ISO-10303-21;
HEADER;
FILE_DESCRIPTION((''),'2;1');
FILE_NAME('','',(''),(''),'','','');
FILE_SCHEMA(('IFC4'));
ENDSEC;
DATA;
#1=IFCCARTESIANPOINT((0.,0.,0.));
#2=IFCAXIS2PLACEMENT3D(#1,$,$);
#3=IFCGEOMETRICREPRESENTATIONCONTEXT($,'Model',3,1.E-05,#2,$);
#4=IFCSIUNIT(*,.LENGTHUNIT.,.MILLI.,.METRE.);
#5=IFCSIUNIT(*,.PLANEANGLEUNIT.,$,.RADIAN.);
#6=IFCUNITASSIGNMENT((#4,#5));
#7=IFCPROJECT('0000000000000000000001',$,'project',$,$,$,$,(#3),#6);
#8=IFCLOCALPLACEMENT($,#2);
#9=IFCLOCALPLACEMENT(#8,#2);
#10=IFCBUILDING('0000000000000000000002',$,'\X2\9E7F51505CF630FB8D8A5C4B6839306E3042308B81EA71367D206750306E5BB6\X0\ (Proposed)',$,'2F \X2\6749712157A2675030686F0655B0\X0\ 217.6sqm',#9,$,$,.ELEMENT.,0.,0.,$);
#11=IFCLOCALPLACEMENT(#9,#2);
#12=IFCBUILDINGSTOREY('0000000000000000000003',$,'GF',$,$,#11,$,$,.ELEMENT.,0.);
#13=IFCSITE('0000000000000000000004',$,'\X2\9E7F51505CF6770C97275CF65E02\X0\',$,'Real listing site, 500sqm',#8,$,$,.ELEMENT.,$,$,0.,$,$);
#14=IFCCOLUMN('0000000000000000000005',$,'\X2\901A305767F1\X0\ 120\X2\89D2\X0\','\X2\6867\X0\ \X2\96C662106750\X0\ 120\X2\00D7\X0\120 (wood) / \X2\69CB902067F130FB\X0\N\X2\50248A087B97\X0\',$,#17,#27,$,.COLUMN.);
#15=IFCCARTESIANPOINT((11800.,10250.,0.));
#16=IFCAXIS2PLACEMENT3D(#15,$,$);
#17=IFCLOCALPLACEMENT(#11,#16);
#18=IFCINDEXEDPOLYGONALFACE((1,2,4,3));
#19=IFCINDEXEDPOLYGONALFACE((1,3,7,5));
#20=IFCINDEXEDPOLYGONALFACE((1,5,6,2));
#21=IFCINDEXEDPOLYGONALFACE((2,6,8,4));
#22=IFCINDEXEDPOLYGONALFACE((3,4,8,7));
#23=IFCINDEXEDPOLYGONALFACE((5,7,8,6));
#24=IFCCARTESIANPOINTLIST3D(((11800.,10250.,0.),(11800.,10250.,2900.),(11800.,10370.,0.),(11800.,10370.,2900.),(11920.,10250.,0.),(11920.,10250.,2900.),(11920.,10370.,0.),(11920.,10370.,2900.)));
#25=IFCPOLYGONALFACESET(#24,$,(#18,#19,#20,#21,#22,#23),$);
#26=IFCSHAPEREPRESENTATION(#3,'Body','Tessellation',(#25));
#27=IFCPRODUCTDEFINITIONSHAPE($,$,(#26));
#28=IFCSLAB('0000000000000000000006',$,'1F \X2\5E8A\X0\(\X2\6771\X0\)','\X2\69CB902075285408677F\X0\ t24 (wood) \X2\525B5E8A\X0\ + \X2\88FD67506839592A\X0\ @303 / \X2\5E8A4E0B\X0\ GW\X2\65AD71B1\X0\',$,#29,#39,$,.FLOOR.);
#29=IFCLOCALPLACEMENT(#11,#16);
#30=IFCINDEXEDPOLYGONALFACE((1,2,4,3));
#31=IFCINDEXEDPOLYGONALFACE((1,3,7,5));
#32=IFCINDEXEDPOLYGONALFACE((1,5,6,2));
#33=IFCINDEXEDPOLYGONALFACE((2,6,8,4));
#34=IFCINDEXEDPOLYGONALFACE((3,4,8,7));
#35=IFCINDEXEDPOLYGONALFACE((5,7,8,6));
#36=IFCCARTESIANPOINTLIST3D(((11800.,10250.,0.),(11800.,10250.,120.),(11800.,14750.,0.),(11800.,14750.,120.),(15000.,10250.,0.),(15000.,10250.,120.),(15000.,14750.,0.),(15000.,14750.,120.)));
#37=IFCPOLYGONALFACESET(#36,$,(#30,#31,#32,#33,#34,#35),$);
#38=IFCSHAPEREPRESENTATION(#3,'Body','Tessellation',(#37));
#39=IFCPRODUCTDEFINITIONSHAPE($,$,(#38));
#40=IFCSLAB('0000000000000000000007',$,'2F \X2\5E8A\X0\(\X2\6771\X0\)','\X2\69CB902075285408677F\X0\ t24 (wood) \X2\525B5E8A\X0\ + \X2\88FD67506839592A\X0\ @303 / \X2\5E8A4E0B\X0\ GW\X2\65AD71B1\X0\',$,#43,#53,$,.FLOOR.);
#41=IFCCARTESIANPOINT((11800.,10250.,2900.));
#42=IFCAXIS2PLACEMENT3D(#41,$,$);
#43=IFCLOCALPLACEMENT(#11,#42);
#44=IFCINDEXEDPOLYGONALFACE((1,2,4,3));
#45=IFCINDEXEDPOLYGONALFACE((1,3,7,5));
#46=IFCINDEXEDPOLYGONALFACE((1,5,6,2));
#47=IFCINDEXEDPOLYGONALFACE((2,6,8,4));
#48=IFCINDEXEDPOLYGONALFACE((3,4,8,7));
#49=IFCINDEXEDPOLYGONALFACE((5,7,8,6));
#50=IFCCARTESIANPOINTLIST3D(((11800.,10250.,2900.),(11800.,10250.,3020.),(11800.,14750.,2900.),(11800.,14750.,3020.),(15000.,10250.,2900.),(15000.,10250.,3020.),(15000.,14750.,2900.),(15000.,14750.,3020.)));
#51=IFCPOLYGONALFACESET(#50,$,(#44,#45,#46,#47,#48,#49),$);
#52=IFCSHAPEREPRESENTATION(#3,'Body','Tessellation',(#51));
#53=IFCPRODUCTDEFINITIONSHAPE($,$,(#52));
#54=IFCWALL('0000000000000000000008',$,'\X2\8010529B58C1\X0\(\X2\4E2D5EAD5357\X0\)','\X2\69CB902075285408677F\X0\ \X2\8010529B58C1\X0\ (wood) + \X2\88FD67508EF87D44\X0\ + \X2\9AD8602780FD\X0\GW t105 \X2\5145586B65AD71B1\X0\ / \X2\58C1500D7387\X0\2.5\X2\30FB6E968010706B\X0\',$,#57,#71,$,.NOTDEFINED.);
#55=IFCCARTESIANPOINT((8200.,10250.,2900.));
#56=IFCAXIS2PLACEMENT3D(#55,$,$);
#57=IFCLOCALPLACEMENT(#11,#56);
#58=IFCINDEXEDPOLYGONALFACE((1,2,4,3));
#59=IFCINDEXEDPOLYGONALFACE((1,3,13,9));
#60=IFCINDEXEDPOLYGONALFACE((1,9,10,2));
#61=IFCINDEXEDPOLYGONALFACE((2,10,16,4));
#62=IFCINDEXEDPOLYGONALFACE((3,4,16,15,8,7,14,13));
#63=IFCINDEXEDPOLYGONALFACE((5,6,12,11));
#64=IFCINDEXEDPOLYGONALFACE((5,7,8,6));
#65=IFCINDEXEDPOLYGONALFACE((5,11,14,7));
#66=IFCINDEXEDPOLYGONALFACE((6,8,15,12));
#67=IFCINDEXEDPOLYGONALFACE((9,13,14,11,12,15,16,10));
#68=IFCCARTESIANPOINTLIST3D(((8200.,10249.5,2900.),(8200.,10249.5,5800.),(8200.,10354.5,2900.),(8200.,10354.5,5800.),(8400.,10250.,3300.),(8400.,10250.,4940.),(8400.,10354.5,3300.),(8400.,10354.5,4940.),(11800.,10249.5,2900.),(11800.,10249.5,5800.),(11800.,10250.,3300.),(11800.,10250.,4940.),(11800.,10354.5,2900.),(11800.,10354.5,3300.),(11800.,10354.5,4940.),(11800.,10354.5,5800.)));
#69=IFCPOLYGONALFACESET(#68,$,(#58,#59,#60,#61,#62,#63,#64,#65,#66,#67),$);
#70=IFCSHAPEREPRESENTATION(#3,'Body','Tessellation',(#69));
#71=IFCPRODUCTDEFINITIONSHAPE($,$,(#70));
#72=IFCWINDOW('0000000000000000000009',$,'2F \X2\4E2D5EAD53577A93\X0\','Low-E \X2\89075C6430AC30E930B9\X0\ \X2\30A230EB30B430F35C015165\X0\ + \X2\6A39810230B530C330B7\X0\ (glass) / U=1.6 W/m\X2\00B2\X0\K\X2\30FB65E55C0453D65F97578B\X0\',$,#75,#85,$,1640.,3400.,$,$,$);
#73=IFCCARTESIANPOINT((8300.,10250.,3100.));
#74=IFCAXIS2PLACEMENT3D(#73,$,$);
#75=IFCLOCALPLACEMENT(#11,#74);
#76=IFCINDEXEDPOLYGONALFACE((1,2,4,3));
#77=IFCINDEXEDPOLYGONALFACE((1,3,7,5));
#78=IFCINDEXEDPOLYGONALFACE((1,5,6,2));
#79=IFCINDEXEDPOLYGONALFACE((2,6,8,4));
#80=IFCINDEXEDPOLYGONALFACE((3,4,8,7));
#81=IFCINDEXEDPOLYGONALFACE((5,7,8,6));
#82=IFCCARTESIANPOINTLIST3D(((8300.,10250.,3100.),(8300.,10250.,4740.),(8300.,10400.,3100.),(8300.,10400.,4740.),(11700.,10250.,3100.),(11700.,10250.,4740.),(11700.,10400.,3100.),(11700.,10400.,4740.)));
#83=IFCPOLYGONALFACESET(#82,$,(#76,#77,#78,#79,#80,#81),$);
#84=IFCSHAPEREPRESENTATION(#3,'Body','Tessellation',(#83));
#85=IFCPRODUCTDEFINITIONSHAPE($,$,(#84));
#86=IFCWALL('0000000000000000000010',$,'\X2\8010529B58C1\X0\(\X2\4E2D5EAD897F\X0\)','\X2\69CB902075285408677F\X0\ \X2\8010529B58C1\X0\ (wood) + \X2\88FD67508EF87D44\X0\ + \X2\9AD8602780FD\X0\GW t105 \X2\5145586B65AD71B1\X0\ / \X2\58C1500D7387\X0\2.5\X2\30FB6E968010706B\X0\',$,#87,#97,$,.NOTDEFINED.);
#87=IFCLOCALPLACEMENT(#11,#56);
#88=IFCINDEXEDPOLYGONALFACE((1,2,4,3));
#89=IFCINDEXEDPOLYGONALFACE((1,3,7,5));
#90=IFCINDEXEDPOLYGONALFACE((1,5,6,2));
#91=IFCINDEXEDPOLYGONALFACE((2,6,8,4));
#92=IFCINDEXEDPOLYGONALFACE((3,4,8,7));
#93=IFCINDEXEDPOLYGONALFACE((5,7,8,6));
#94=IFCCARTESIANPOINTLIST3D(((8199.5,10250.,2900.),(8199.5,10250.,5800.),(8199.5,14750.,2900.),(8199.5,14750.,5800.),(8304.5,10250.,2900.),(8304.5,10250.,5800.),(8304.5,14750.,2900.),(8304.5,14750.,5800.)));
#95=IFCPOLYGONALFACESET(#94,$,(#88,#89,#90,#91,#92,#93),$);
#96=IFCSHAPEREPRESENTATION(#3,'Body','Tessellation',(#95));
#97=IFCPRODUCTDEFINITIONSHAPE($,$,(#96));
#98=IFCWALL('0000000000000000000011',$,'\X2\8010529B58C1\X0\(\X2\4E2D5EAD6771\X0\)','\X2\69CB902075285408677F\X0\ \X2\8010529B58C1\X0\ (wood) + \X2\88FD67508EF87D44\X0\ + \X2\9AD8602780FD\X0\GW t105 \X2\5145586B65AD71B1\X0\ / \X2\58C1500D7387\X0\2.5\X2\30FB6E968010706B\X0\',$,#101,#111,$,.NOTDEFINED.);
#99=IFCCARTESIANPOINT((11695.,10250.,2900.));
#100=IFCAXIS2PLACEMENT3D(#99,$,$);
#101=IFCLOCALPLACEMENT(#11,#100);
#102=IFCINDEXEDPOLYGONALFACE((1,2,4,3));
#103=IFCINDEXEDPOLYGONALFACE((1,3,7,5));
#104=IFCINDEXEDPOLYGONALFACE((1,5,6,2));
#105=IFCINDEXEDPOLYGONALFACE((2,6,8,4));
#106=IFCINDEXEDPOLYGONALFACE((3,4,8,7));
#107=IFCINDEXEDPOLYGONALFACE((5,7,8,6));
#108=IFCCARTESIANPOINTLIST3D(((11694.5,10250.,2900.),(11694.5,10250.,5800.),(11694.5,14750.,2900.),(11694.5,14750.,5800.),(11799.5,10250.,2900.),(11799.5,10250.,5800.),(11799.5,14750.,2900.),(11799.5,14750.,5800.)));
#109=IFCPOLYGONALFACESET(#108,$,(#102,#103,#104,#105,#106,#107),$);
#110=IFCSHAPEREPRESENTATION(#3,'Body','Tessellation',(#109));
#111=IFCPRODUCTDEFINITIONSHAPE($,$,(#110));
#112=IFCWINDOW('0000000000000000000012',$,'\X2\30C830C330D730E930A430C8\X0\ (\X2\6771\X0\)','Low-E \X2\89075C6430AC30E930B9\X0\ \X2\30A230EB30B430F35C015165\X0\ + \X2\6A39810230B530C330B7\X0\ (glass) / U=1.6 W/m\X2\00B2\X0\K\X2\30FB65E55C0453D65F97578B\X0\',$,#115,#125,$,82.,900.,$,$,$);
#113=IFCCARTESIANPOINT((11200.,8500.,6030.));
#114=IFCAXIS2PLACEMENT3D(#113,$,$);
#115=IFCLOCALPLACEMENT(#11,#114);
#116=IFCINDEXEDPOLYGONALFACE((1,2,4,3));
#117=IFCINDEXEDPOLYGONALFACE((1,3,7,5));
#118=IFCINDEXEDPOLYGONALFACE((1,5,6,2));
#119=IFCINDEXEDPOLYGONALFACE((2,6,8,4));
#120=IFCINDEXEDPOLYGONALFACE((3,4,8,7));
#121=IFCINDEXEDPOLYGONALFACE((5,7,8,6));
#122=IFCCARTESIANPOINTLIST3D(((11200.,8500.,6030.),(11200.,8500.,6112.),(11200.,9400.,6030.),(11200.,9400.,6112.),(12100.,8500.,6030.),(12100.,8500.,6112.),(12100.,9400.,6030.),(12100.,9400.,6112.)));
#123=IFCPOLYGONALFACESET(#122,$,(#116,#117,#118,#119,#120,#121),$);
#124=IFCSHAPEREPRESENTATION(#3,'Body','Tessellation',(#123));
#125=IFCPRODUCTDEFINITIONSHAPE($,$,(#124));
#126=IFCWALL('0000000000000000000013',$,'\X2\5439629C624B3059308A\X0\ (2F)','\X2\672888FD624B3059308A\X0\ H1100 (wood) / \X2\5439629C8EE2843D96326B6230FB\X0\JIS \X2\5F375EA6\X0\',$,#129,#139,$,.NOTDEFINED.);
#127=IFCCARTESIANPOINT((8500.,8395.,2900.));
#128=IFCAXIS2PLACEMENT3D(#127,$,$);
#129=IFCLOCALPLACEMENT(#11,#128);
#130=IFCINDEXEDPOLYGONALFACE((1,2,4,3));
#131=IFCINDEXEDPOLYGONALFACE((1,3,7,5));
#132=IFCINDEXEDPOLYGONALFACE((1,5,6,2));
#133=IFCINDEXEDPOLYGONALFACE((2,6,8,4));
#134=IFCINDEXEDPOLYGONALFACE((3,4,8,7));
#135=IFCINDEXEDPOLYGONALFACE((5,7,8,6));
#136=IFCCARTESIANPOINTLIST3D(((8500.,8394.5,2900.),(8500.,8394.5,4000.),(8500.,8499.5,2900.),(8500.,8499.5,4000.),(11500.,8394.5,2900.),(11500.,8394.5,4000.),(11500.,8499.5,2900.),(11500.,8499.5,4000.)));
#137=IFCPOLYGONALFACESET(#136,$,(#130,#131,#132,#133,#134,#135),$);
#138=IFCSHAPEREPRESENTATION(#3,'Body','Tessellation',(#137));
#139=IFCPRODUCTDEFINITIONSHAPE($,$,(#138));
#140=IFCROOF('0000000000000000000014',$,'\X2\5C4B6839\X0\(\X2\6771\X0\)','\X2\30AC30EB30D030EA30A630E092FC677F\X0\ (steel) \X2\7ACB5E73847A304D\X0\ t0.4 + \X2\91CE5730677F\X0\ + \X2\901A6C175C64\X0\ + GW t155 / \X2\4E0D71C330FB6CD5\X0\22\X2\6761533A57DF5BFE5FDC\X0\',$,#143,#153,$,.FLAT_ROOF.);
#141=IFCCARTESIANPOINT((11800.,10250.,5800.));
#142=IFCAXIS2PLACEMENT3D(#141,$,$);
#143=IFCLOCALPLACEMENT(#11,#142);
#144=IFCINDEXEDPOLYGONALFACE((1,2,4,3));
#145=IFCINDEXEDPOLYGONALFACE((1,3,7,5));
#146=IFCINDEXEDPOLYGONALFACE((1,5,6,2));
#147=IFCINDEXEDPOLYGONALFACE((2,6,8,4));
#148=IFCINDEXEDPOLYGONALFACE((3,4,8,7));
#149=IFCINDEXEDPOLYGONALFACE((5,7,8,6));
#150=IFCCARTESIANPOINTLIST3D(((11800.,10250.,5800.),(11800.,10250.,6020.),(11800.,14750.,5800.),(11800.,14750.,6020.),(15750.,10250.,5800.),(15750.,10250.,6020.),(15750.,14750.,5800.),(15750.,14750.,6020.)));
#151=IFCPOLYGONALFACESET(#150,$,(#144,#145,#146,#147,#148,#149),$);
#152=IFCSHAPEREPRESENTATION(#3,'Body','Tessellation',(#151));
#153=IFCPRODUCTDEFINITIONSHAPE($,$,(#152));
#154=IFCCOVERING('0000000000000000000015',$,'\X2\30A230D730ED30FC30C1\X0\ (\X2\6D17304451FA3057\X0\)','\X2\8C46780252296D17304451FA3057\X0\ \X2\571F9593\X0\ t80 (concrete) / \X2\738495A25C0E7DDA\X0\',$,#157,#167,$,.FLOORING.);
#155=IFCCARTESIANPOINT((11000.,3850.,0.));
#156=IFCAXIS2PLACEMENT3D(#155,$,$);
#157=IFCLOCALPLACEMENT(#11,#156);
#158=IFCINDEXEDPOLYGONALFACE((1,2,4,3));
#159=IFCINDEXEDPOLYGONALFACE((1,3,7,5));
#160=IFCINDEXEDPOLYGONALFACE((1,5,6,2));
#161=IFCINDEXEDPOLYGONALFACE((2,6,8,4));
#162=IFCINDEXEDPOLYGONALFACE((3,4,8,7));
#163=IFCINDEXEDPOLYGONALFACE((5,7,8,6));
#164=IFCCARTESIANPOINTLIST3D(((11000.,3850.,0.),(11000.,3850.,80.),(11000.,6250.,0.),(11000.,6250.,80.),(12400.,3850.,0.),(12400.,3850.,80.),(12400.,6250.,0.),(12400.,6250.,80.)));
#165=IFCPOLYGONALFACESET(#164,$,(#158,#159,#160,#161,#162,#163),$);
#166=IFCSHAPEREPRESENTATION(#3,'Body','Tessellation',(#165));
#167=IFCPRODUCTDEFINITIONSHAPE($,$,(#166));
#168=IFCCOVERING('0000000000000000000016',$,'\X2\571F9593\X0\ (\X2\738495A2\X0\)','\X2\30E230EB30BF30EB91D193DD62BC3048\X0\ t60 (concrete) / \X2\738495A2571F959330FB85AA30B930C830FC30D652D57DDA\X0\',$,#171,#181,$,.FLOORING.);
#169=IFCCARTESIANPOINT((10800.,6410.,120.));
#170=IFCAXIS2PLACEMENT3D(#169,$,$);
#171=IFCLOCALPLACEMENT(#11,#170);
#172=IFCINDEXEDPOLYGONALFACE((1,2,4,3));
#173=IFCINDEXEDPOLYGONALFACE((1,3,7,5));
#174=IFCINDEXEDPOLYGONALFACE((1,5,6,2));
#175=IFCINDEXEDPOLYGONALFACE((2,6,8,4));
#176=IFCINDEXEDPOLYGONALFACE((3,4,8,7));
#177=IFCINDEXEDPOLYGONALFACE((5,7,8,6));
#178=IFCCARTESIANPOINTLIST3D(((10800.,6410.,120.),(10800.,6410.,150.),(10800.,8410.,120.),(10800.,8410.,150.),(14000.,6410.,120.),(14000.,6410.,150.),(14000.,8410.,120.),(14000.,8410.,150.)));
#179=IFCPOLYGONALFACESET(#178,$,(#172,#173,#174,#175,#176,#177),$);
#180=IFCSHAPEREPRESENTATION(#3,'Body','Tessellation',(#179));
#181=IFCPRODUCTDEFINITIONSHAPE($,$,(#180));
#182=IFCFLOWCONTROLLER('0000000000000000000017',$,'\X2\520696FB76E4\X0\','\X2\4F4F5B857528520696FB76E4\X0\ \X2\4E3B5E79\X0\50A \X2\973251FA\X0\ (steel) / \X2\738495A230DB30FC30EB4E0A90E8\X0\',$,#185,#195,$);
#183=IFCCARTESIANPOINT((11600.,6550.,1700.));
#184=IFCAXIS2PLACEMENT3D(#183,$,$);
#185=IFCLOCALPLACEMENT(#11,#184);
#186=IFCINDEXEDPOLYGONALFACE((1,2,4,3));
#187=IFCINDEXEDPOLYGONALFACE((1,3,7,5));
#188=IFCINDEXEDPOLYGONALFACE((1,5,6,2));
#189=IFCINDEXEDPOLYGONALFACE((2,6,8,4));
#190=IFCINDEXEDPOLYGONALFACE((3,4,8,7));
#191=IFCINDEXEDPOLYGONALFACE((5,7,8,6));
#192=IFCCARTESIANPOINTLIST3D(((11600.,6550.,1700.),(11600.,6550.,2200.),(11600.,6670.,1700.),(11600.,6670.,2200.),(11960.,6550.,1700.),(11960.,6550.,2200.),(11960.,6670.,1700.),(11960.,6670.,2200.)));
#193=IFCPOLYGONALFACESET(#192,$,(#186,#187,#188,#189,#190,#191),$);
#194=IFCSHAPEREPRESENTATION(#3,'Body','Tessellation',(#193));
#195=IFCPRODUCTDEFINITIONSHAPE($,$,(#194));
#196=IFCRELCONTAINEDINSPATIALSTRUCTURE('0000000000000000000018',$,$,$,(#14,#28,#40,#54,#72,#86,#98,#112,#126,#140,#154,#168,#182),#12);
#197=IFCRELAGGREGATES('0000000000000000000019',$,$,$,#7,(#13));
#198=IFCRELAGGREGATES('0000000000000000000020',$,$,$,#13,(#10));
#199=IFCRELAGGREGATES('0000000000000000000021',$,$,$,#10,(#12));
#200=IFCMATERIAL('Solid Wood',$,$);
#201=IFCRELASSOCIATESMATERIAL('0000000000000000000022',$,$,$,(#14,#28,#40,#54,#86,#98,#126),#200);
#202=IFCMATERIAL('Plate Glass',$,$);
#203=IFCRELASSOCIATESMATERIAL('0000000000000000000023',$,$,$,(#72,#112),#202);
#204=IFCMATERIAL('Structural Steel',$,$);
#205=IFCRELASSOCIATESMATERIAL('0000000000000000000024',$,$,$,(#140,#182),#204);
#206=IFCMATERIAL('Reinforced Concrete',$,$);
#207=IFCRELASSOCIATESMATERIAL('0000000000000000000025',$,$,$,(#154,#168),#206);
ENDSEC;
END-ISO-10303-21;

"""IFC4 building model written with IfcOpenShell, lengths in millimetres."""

from ifc_helpers import new_model, si_unit, frame, frame_2d, origin, place, context, project, spatial, rectangle, extrude, material, element, fill, save


model = new_model("IFC4")

# Units and contexts
model_context = context("Model", 3, precision=1e-05, world=origin())
ifc_project = project(units=[si_unit("LENGTHUNIT", "METRE", prefix="MILLI"), si_unit("PLANEANGLEUNIT", "RADIAN")], contexts=[model_context])

# Site, building, storey
site_placement = place(None, origin())
site = spatial("IfcSite", under=ifc_project, at=site_placement, Name="鹿児島県霧島市", ObjectType="Real listing site, 500sqm", CompositionType="ELEMENT", RefElevation=0.0)
building_placement = place(site_placement, origin())
building = spatial("IfcBuilding", under=site, at=building_placement, Name="鹿児島・越屋根のある自然素材の家 (Proposed)", ObjectType="2F 杉無垢材と漆喰 217.6sqm", CompositionType="ELEMENT", ElevationOfRefHeight=0.0, ElevationOfTerrain=0.0)
storey_placement = place(building_placement, origin())
storey = spatial("IfcBuildingStorey", under=building, at=storey_placement, Name="GF", CompositionType="ELEMENT", Elevation=0.0)

# Column
ifc_material_1 = material(Name="Solid Wood")
column_1_placement = place(storey_placement, frame((11800.0, 10250.0, 0.0)))
element("IfcColumn", 1, at=column_1_placement, inside=storey, material=ifc_material_1, Name="通し柱 120角", Description="桧 集成材 120×120 (wood) / 構造柱・N値計算", PredefinedType="COLUMN", context=model_context, shape_type="SweptSolid", body=[
    extrude(rectangle(XDim=120.0, YDim=120.0, at=frame_2d((60.0, 60.0))), frame((11800.0, 10250.0, 0.0)), (0.0, 0.0, 1.0), 2900.0),
])

# Slabs
slab_1_placement = place(storey_placement, frame((11800.0, 10250.0, 0.0)))
element("IfcSlab", 2, at=slab_1_placement, inside=storey, material=ifc_material_1, Name="1F 床(東)", Description="構造用合板 t24 (wood) 剛床 + 製材根太 @303 / 床下 GW断熱", PredefinedType="FLOOR", context=model_context, shape_type="SweptSolid", body=[
    extrude(rectangle(XDim=3200.0, YDim=4500.0, at=frame_2d((1600.0, 2250.0))), frame((11800.0, 10250.0, 0.0)), (0.0, 0.0, 1.0), 120.0),
])
slab_2_placement = place(storey_placement, frame((11800.0, 10250.0, 2900.0)))
element("IfcSlab", 3, at=slab_2_placement, inside=storey, material=ifc_material_1, Name="2F 床(東)", Description="構造用合板 t24 (wood) 剛床 + 製材根太 @303 / 床下 GW断熱", PredefinedType="FLOOR", context=model_context, shape_type="SweptSolid", body=[
    extrude(rectangle(XDim=3200.0, YDim=4500.0, at=frame_2d((1600.0, 2250.0))), frame((11800.0, 10250.0, 2900.0)), (0.0, 0.0, 1.0), 120.0),
])

# Wall, opening, window
wall_1_placement = place(storey_placement, frame((8200.0, 10250.0, 2900.0)))
wall_1 = element("IfcWall", 4, at=wall_1_placement, inside=storey, material=ifc_material_1, Name="耐力壁(中庭南)", Description="構造用合板 耐力壁 (wood) + 製材軸組 + 高性能GW t105 充填断熱 / 壁倍率2.5・準耐火", PredefinedType="NOTDEFINED", context=model_context, shape_type="SweptSolid", body=[
    extrude(rectangle(XDim=3600.0, YDim=105.0, at=frame_2d((1800.0, 52.0))), frame((8200.0, 10250.0, 2900.0)), (0.0, 0.0, 1.0), 2900.0),
])
opening_placement = place(storey_placement, frame((8300.0, 10250.0, 3100.0)))
opening = element("IfcOpeningElement", 5, at=opening_placement, cuts=wall_1, PredefinedType="NOTDEFINED", context=model_context, shape_type="SweptSolid", body=[
    extrude(rectangle(XDim=3400.0, YDim=150.0, at=frame_2d((1700.0, 75.0))), frame((8300.0, 10250.0, 3100.0)), (0.0, 0.0, 1.0), 1640.0),
])
ifc_material_2 = material(Name="Plate Glass")
window_1_placement = place(storey_placement, frame((8300.0, 10250.0, 3100.0)))
window_1 = element("IfcWindow", 6, at=window_1_placement, inside=storey, material=ifc_material_2, Name="2F 中庭南窓", Description="Low-E 複層ガラス アルゴン封入 + 樹脂サッシ (glass) / U=1.6 W/m²K・日射取得型", OverallHeight=1640.0, OverallWidth=3400.0, context=model_context, shape_type="SweptSolid", body=[
    extrude(rectangle(XDim=3400.0, YDim=150.0, at=frame_2d((1700.0, 75.0))), frame((8300.0, 10250.0, 3100.0)), (0.0, 0.0, 1.0), 1640.0),
])
fill(opening, window_1)

# Walls
wall_2_placement = place(storey_placement, frame((8200.0, 10250.0, 2900.0)))
element("IfcWall", 7, at=wall_2_placement, inside=storey, material=ifc_material_1, Name="耐力壁(中庭西)", Description="構造用合板 耐力壁 (wood) + 製材軸組 + 高性能GW t105 充填断熱 / 壁倍率2.5・準耐火", PredefinedType="NOTDEFINED", context=model_context, shape_type="SweptSolid", body=[
    extrude(rectangle(XDim=105.0, YDim=4500.0, at=frame_2d((52.0, 2250.0))), frame((8200.0, 10250.0, 2900.0)), (0.0, 0.0, 1.0), 2900.0),
])
wall_3_placement = place(storey_placement, frame((11695.0, 10250.0, 2900.0)))
element("IfcWall", 8, at=wall_3_placement, inside=storey, material=ifc_material_1, Name="耐力壁(中庭東)", Description="構造用合板 耐力壁 (wood) + 製材軸組 + 高性能GW t105 充填断熱 / 壁倍率2.5・準耐火", PredefinedType="NOTDEFINED", context=model_context, shape_type="SweptSolid", body=[
    extrude(rectangle(XDim=105.0, YDim=4500.0, at=frame_2d((52.0, 2250.0))), frame((11695.0, 10250.0, 2900.0)), (0.0, 0.0, 1.0), 2900.0),
])

# Window
window_2_placement = place(storey_placement, frame((11200.0, 8500.0, 6030.0)))
element("IfcWindow", 9, at=window_2_placement, inside=storey, material=ifc_material_2, Name="トップライト (東)", Description="Low-E 複層ガラス アルゴン封入 + 樹脂サッシ (glass) / U=1.6 W/m²K・日射取得型", OverallHeight=82.0, OverallWidth=900.0, context=model_context, shape_type="SweptSolid", body=[
    extrude(rectangle(XDim=900.0, YDim=900.0, at=frame_2d((450.0, 450.0))), frame((11200.0, 8500.0, 6030.0)), (0.0, 0.0, 1.0), 82.0),
])

# Wall
wall_4_placement = place(storey_placement, frame((8500.0, 8395.0, 2900.0)))
element("IfcWall", 10, at=wall_4_placement, inside=storey, material=ifc_material_1, Name="吹抜手すり (2F)", Description="木製手すり H1100 (wood) / 吹抜転落防止・JIS 強度", PredefinedType="NOTDEFINED", context=model_context, shape_type="SweptSolid", body=[
    extrude(rectangle(XDim=3000.0, YDim=105.0, at=frame_2d((1500.0, 52.0))), frame((8500.0, 8395.0, 2900.0)), (0.0, 0.0, 1.0), 1100.0),
])

# Roof
ifc_material_3 = material(Name="Structural Steel")
for number, where, name in (
    (11, (11800.0, 10250.0, 5800.0), "屋根(東)"),
):
    element("IfcRoof", number, at=place(storey_placement, frame(where)), inside=storey, material=ifc_material_3, Name=name, Description="ガルバリウム鋼板 (steel) 立平葺き t0.4 + 野地板 + 通気層 + GW t155 / 不燃・法22条区域対応", PredefinedType="FLAT_ROOF", context=model_context, shape_type="SweptSolid", body=[
        extrude(rectangle(XDim=3950.0, YDim=4500.0, at=frame_2d((1975.0, 2250.0))), frame((11800.0, 10250.0, 5800.0)), (0.0, 0.0, 1.0), 220.0),
    ])

# Coverings
ifc_material_4 = material(Name="Reinforced Concrete")
covering_1_placement = place(storey_placement, frame((11000.0, 3850.0, 0.0)))
element("IfcCovering", 12, at=covering_1_placement, inside=storey, material=ifc_material_4, Name="アプローチ (洗い出し)", Description="豆砂利洗い出し 土間 t80 (concrete) / 玄関導線", PredefinedType="FLOORING", context=model_context, shape_type="SweptSolid", body=[
    extrude(rectangle(XDim=1400.0, YDim=2400.0, at=frame_2d((700.0, 1200.0))), frame((11000.0, 3850.0, 0.0)), (0.0, 0.0, 1.0), 80.0),
])
covering_2_placement = place(storey_placement, frame((10800.0, 6410.0, 120.0)))
element("IfcCovering", 13, at=covering_2_placement, inside=storey, material=ifc_material_4, Name="土間 (玄関)", Description="モルタル金鏝押え t60 (concrete) / 玄関土間・薪ストーブ動線", PredefinedType="FLOORING", context=model_context, shape_type="SweptSolid", body=[
    extrude(rectangle(XDim=3200.0, YDim=2000.0, at=frame_2d((1600.0, 1000.0))), frame((10800.0, 6410.0, 120.0)), (0.0, 0.0, 1.0), 30.0),
])

# Flow controller
flow_controller_placement = place(storey_placement, frame((11600.0, 6550.0, 1700.0)))
element("IfcFlowController", 14, at=flow_controller_placement, inside=storey, material=ifc_material_3, Name="分電盤", Description="住宅用分電盤 主幹50A 露出 (steel) / 玄関ホール上部", context=model_context, shape_type="SweptSolid", body=[
    extrude(rectangle(XDim=360.0, YDim=120.0, at=frame_2d((180.0, 60.0))), frame((11600.0, 6550.0, 1700.0)), (0.0, 0.0, 1.0), 500.0),
])

save(model, "model.ifc")
